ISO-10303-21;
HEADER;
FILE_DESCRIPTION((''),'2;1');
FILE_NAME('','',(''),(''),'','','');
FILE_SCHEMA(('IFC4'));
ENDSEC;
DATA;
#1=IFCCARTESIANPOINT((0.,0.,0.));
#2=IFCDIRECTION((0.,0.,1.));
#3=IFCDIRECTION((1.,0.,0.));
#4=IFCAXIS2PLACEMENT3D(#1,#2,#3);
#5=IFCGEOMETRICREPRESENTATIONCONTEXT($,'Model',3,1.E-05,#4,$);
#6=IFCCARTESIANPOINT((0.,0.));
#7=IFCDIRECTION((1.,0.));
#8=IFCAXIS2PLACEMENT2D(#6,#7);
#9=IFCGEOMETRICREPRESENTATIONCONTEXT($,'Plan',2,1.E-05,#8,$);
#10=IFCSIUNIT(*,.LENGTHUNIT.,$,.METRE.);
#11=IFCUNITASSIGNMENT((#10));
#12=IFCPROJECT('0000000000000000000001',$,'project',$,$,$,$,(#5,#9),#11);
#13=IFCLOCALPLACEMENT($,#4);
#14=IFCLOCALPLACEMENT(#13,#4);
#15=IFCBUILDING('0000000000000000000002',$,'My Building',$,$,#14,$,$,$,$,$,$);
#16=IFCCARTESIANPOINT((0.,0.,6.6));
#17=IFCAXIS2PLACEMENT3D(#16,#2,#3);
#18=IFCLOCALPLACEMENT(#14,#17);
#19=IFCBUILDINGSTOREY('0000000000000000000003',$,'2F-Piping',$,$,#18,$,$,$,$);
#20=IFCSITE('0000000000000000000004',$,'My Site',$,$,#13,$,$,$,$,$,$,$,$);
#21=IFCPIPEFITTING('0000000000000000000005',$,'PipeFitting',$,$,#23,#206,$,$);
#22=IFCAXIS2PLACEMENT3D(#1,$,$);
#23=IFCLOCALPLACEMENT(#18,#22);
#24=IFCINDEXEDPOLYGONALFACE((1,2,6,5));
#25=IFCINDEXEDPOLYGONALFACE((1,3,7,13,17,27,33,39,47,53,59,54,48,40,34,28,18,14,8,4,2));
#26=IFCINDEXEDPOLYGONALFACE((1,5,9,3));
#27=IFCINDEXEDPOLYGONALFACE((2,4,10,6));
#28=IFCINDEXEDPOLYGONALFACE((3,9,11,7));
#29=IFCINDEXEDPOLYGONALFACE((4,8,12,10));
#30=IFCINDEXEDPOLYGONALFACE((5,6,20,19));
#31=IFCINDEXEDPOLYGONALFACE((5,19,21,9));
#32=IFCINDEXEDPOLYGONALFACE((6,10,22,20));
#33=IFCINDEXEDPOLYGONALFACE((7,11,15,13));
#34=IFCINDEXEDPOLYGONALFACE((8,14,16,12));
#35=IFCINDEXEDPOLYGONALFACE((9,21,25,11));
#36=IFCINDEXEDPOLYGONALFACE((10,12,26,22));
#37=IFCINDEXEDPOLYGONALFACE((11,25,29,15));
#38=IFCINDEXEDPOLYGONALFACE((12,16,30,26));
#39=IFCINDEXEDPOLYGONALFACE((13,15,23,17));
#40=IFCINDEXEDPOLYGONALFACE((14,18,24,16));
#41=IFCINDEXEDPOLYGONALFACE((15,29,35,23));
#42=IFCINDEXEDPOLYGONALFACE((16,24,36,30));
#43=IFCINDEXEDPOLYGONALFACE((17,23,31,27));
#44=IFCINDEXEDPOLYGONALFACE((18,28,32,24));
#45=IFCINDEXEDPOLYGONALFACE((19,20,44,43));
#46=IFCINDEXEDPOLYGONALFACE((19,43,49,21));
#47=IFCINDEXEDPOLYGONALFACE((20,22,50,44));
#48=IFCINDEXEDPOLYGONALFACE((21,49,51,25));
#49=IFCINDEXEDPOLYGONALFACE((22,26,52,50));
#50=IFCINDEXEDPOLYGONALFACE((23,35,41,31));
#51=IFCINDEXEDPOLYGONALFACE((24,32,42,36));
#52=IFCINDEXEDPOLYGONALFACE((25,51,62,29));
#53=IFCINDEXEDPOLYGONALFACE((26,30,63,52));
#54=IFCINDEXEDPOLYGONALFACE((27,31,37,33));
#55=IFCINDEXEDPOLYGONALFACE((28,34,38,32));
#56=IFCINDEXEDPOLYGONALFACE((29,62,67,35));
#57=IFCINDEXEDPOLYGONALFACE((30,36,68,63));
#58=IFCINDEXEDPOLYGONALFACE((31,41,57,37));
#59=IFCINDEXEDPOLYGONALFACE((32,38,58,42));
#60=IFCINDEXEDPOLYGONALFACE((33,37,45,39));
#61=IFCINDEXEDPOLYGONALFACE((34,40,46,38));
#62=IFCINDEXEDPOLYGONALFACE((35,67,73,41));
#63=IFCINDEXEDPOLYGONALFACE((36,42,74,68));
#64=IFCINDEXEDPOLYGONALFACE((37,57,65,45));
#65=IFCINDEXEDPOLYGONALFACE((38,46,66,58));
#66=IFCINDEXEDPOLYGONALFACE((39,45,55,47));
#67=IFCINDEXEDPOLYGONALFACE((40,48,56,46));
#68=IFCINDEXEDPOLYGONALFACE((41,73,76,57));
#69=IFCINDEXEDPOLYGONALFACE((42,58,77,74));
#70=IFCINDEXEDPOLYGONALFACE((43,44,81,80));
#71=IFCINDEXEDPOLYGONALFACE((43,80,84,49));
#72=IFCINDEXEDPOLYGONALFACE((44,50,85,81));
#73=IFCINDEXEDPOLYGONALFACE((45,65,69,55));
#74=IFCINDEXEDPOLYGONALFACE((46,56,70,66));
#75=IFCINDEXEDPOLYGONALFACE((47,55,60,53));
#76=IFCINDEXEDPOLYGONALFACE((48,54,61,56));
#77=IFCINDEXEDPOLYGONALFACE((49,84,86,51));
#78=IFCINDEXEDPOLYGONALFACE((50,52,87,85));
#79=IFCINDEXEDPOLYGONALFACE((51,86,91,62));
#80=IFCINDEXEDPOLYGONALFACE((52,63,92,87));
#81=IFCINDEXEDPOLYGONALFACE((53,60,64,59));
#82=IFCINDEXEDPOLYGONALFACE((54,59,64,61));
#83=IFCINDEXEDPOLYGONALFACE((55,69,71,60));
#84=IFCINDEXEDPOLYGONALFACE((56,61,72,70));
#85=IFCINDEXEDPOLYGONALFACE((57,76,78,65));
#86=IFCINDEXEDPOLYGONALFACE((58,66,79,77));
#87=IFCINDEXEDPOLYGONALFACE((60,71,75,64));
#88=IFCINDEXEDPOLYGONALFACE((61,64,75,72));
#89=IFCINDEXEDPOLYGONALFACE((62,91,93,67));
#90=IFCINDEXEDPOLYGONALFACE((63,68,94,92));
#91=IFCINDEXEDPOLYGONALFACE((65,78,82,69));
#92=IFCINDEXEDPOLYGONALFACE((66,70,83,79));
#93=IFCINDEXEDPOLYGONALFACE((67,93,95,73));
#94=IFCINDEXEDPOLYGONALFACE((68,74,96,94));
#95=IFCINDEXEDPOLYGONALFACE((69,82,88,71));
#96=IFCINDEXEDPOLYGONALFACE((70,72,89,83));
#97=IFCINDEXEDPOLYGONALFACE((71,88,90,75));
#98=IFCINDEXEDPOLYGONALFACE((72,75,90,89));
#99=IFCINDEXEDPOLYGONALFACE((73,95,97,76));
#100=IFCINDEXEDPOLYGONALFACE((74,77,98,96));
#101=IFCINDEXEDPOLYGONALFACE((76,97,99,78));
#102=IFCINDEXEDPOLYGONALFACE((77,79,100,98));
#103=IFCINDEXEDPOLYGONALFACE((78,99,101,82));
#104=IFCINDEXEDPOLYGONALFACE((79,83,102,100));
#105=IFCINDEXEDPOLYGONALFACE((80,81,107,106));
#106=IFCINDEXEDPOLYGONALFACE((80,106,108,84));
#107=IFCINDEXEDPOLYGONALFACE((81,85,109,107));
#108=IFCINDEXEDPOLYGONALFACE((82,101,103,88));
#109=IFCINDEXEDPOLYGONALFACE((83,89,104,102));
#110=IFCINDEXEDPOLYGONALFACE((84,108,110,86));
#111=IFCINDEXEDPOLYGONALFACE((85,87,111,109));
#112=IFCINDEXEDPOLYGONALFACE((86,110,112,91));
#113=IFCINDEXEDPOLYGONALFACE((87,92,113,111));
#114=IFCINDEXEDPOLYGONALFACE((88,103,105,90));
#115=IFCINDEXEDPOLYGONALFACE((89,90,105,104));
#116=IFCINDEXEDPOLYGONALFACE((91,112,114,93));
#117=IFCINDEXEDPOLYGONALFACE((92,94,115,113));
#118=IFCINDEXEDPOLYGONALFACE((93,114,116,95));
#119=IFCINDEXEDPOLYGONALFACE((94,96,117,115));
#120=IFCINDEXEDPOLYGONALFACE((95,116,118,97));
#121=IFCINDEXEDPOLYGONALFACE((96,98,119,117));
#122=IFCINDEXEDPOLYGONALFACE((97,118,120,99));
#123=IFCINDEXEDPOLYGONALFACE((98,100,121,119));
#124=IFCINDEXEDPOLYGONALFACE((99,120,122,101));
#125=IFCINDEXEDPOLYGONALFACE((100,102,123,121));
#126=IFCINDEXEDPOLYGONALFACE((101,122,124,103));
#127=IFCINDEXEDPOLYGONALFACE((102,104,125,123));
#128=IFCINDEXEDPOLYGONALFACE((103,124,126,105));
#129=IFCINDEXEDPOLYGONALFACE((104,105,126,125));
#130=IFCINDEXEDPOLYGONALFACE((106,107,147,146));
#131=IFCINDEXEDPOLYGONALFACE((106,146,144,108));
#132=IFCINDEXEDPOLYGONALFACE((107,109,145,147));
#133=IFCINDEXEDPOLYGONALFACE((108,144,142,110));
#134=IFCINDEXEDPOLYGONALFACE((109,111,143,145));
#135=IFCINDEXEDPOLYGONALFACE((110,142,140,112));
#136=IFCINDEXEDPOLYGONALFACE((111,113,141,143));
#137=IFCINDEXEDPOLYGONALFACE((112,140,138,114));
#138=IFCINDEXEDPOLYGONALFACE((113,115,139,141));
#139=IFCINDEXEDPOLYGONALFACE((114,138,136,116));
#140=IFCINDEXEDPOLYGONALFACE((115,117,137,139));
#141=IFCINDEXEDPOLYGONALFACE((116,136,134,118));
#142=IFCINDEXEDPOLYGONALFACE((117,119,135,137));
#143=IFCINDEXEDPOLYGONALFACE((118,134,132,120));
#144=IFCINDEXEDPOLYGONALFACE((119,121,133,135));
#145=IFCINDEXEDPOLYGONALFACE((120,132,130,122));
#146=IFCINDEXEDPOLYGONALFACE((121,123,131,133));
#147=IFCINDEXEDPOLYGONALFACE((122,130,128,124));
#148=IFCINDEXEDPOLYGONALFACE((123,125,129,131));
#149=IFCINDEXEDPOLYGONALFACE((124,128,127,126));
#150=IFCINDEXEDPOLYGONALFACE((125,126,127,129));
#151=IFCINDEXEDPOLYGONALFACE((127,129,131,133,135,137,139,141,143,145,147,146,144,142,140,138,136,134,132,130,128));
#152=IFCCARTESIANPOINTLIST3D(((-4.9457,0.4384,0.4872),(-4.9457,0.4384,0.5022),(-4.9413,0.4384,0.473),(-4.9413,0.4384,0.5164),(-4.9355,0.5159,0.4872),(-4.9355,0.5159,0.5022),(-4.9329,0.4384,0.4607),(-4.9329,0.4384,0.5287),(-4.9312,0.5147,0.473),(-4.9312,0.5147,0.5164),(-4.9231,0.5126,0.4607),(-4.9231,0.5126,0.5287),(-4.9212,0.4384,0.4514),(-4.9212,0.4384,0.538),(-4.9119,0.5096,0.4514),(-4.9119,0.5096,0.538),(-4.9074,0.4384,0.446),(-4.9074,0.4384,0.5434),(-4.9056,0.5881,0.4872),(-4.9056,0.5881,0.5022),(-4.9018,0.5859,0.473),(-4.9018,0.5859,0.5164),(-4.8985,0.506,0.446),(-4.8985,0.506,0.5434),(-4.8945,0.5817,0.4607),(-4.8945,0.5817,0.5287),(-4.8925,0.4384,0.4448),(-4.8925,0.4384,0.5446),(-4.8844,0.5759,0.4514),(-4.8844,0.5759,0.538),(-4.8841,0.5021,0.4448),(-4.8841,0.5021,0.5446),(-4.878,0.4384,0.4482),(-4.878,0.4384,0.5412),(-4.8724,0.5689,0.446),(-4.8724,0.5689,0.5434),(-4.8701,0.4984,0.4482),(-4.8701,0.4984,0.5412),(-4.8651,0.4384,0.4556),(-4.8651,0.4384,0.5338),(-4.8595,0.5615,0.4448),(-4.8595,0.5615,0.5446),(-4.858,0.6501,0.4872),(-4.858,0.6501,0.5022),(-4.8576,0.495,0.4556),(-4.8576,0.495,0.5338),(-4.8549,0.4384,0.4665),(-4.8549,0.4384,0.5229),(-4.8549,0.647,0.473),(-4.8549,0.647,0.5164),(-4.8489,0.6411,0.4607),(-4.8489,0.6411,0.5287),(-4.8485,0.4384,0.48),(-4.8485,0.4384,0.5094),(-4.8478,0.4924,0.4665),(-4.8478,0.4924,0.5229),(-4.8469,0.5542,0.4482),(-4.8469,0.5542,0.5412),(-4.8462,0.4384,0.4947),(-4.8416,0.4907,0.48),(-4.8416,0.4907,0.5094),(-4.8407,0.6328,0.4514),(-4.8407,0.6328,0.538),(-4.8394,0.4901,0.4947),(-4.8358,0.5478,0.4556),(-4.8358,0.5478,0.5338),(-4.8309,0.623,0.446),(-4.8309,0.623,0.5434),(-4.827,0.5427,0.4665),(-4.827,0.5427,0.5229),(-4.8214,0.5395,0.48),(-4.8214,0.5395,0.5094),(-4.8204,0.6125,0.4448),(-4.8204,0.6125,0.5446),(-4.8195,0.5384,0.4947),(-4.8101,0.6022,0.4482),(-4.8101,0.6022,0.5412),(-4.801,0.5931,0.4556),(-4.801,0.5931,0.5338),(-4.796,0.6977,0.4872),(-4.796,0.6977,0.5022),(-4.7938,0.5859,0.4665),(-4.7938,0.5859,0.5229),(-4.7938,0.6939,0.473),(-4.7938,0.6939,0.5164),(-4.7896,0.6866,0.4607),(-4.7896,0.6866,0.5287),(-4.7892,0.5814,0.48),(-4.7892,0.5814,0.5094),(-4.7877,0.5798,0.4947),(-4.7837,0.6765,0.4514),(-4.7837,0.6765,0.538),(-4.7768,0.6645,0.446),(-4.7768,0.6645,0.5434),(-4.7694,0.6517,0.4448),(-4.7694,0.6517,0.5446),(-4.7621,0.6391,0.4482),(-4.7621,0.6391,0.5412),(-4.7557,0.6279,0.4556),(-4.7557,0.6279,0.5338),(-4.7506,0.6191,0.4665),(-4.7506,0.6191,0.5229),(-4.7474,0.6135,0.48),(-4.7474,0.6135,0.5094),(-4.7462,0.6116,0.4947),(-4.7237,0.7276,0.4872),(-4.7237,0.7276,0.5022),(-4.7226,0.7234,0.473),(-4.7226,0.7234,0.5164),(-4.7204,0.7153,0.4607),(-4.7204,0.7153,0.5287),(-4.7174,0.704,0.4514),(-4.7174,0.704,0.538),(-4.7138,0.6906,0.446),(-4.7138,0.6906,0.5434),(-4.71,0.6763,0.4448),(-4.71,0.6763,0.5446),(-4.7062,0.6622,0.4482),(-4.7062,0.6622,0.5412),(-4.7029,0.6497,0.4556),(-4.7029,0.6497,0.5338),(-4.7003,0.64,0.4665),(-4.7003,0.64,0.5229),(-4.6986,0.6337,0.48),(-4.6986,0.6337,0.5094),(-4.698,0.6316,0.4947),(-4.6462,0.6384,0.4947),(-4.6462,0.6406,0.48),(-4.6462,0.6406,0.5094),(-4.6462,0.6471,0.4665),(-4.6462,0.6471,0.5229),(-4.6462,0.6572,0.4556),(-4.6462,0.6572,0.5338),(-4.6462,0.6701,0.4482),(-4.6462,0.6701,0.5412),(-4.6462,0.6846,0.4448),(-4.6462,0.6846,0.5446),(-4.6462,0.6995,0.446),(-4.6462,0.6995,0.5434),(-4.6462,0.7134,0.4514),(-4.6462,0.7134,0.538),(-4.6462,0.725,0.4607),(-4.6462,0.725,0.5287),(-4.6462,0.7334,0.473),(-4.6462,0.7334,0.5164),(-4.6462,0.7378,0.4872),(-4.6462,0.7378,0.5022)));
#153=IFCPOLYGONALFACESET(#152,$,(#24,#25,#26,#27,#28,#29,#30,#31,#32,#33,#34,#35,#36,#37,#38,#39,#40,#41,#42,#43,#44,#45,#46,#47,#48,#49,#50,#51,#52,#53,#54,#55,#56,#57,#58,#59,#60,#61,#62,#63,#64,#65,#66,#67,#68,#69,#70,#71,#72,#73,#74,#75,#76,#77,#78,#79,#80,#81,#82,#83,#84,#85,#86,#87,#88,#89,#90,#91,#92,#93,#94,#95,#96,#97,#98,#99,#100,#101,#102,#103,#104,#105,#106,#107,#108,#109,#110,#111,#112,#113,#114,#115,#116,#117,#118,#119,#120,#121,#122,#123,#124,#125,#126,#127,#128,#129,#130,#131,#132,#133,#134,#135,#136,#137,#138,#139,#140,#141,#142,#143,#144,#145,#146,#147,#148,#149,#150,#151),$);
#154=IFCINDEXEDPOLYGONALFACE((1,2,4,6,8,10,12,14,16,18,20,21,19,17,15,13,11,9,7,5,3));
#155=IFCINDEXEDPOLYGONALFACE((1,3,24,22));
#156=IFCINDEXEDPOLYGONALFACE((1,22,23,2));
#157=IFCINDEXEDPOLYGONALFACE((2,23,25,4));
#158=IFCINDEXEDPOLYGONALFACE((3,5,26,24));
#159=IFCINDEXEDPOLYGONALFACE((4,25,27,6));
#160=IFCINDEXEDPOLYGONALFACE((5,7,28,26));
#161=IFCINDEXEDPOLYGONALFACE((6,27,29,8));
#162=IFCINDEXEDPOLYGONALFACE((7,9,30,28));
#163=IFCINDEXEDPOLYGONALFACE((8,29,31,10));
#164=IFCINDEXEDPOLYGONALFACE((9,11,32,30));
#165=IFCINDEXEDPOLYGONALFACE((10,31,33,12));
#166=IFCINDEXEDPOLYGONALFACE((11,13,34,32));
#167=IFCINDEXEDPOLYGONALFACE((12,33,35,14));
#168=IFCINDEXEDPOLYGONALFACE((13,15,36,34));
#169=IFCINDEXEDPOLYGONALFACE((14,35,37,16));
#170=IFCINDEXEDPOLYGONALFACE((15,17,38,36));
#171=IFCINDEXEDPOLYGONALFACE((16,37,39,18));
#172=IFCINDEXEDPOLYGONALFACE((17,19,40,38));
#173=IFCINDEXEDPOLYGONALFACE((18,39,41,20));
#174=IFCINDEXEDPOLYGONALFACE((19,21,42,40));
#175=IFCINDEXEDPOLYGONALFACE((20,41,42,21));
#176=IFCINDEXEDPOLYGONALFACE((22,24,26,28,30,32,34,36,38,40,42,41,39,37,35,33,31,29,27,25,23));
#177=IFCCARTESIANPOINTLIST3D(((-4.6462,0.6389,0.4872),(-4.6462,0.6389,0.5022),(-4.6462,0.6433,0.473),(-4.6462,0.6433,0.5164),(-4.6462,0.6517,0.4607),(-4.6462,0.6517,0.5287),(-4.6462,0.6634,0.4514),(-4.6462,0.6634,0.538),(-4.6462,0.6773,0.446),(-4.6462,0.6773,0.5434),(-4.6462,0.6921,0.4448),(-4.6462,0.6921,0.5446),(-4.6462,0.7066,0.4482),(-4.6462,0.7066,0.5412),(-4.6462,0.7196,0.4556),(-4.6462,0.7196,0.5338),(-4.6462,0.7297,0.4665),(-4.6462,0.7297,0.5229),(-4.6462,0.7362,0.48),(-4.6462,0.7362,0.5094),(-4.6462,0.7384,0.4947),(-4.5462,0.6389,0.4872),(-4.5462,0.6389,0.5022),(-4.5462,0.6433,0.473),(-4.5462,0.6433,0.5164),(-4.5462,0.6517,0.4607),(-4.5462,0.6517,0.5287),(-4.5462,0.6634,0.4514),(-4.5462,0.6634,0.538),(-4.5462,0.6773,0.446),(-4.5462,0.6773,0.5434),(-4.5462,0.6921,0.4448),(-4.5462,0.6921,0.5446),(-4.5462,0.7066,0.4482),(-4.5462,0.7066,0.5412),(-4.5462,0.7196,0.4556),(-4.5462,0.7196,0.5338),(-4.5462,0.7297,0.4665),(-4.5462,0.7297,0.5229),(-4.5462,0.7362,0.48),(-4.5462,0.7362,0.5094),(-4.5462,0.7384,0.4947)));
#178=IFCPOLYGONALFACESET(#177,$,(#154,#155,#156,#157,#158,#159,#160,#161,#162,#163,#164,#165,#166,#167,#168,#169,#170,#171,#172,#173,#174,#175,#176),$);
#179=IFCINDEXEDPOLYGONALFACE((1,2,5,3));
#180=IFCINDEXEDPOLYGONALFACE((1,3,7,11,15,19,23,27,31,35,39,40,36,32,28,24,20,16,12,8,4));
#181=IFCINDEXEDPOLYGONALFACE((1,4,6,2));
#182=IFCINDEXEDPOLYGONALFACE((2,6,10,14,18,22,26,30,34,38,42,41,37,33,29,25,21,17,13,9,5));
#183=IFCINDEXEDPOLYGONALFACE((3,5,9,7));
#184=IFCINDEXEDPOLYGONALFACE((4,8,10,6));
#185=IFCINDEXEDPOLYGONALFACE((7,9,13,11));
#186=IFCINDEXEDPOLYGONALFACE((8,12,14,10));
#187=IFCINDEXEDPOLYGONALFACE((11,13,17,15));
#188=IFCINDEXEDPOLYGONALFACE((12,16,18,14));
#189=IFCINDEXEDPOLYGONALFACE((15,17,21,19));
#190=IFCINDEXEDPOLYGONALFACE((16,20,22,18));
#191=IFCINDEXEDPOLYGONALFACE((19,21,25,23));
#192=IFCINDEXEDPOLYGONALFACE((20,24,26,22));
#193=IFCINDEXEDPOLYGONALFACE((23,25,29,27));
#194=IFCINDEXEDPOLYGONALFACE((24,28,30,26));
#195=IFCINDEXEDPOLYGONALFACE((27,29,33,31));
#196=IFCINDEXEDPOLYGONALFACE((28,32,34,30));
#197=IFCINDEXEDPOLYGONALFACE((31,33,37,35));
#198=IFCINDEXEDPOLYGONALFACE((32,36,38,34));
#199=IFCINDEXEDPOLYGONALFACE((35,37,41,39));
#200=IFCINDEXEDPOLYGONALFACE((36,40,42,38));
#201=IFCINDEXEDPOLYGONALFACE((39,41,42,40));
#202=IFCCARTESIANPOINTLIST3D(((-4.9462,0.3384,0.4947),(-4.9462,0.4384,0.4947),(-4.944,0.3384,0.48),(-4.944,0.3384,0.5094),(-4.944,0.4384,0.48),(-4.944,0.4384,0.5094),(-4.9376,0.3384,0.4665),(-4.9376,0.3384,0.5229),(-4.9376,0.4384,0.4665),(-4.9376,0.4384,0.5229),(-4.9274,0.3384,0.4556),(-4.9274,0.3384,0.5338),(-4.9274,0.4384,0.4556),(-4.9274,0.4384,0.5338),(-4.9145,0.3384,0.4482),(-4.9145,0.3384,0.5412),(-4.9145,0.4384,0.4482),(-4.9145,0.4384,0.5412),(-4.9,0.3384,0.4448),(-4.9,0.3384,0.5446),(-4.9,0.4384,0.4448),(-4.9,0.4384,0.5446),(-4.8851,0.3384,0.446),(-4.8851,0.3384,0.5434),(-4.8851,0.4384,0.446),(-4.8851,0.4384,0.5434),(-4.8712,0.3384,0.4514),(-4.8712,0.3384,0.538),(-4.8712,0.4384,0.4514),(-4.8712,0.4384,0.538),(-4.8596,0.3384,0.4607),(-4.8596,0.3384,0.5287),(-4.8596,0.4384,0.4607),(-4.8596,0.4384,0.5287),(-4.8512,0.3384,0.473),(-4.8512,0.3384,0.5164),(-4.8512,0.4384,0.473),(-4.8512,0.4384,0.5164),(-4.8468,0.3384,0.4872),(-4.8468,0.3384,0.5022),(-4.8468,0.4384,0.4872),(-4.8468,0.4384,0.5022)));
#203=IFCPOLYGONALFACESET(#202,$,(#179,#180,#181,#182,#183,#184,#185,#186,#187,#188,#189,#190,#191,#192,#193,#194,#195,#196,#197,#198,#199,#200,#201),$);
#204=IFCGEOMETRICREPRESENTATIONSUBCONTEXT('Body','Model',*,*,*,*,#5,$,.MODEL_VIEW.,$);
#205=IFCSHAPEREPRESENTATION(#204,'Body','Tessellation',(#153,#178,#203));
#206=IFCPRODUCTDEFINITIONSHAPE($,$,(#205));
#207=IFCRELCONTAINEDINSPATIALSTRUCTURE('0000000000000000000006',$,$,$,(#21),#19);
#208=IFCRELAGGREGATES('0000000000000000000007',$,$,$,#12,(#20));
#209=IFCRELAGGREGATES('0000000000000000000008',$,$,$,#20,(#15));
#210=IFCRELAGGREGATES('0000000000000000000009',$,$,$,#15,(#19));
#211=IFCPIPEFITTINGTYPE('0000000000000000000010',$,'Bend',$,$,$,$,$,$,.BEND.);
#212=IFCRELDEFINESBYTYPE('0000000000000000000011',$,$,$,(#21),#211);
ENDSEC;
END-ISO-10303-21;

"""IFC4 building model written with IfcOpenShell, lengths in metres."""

from ifc_helpers import new_model, entity, si_unit, frame, origin_with_axes, origin_2d_with_axis, place, context, subcontext, project, spatial, circle, extrude, source, transform, mapped, type_object, type_shapes, element, save


model = new_model("IFC4")

# Units and contexts
model_context = context("Model", 3, precision=1e-05, world=origin_with_axes())
plan_context = context("Plan", 2, precision=1e-05, world=origin_2d_with_axis())
body_context = subcontext(model_context, "Body", "Model", "MODEL_VIEW")
ifc_project = project(units=[si_unit("LENGTHUNIT", "METRE")], contexts=[model_context, plan_context])

# Site, building, storey
site_placement = place(None, origin_with_axes())
site = spatial("IfcSite", under=ifc_project, at=site_placement, Name="My Site")
building_placement = place(site_placement, origin_with_axes())
building = spatial("IfcBuilding", under=site, at=building_placement, Name="My Building")
storey_placement = place(building_placement, frame((0.0, 0.0, 6.6), z_axis=(0.0, 0.0, 1.0), x_axis=(1.0, 0.0, 0.0)))
storey = spatial("IfcBuildingStorey", under=building, at=storey_placement, Name="2F-Piping")

# Pipe fitting
pipe_fitting_type = type_object("IfcPipeFittingType", Name="Bend", PredefinedType="BEND")
shared_shape = source(origin_with_axes(), body_context, "Body", "SolidModel", [
    entity("IfcSweptDiskSolid", entity("IfcIndexedPolyCurve", entity("IfcCartesianPointList3D", [[0.0, 0.0, -0.1], [-0.0732, 0.0, -0.2768], [-0.25, 0.0, -0.35]]), [entity("IfcArcIndex", [1, 2, 3])]), 0.05),
    extrude(circle(Radius=0.05), origin_with_axes(), (0.0, 0.0, -1.0), 0.1),
    extrude(circle(Radius=0.05), frame((-0.25, 0.0, -0.35), z_axis=(-1.0, 0.0, 0.0), x_axis=(0.0, 0.0, -1.0)), (0.0, 0.0, 1.0), 0.1),
])
type_shapes(pipe_fitting_type, [shared_shape])
for number, where, z_axis, x_axis, name in (
    (1, (-4.5462, 0.6884, 0.4947), (1.0, 0.0, 0.0), (0.0, 1.0, 0.0), "PipeFitting"),
):
    element("IfcPipeFitting", number, at=place(storey_placement, frame(where, z_axis=z_axis, x_axis=x_axis)), inside=storey, type_object=pipe_fitting_type, Name=name, context=body_context, shape_type="MappedRepresentation", body=[
        mapped(shared_shape, transform((0.0, 0.0, 0.0), x_axis=(1.0, 0.0, 0.0), y_axis=(0.0, 1.0, 0.0), z_axis=(0.0, 0.0, 1.0), scale=1.0)),
    ])

save(model, "model.ifc")
